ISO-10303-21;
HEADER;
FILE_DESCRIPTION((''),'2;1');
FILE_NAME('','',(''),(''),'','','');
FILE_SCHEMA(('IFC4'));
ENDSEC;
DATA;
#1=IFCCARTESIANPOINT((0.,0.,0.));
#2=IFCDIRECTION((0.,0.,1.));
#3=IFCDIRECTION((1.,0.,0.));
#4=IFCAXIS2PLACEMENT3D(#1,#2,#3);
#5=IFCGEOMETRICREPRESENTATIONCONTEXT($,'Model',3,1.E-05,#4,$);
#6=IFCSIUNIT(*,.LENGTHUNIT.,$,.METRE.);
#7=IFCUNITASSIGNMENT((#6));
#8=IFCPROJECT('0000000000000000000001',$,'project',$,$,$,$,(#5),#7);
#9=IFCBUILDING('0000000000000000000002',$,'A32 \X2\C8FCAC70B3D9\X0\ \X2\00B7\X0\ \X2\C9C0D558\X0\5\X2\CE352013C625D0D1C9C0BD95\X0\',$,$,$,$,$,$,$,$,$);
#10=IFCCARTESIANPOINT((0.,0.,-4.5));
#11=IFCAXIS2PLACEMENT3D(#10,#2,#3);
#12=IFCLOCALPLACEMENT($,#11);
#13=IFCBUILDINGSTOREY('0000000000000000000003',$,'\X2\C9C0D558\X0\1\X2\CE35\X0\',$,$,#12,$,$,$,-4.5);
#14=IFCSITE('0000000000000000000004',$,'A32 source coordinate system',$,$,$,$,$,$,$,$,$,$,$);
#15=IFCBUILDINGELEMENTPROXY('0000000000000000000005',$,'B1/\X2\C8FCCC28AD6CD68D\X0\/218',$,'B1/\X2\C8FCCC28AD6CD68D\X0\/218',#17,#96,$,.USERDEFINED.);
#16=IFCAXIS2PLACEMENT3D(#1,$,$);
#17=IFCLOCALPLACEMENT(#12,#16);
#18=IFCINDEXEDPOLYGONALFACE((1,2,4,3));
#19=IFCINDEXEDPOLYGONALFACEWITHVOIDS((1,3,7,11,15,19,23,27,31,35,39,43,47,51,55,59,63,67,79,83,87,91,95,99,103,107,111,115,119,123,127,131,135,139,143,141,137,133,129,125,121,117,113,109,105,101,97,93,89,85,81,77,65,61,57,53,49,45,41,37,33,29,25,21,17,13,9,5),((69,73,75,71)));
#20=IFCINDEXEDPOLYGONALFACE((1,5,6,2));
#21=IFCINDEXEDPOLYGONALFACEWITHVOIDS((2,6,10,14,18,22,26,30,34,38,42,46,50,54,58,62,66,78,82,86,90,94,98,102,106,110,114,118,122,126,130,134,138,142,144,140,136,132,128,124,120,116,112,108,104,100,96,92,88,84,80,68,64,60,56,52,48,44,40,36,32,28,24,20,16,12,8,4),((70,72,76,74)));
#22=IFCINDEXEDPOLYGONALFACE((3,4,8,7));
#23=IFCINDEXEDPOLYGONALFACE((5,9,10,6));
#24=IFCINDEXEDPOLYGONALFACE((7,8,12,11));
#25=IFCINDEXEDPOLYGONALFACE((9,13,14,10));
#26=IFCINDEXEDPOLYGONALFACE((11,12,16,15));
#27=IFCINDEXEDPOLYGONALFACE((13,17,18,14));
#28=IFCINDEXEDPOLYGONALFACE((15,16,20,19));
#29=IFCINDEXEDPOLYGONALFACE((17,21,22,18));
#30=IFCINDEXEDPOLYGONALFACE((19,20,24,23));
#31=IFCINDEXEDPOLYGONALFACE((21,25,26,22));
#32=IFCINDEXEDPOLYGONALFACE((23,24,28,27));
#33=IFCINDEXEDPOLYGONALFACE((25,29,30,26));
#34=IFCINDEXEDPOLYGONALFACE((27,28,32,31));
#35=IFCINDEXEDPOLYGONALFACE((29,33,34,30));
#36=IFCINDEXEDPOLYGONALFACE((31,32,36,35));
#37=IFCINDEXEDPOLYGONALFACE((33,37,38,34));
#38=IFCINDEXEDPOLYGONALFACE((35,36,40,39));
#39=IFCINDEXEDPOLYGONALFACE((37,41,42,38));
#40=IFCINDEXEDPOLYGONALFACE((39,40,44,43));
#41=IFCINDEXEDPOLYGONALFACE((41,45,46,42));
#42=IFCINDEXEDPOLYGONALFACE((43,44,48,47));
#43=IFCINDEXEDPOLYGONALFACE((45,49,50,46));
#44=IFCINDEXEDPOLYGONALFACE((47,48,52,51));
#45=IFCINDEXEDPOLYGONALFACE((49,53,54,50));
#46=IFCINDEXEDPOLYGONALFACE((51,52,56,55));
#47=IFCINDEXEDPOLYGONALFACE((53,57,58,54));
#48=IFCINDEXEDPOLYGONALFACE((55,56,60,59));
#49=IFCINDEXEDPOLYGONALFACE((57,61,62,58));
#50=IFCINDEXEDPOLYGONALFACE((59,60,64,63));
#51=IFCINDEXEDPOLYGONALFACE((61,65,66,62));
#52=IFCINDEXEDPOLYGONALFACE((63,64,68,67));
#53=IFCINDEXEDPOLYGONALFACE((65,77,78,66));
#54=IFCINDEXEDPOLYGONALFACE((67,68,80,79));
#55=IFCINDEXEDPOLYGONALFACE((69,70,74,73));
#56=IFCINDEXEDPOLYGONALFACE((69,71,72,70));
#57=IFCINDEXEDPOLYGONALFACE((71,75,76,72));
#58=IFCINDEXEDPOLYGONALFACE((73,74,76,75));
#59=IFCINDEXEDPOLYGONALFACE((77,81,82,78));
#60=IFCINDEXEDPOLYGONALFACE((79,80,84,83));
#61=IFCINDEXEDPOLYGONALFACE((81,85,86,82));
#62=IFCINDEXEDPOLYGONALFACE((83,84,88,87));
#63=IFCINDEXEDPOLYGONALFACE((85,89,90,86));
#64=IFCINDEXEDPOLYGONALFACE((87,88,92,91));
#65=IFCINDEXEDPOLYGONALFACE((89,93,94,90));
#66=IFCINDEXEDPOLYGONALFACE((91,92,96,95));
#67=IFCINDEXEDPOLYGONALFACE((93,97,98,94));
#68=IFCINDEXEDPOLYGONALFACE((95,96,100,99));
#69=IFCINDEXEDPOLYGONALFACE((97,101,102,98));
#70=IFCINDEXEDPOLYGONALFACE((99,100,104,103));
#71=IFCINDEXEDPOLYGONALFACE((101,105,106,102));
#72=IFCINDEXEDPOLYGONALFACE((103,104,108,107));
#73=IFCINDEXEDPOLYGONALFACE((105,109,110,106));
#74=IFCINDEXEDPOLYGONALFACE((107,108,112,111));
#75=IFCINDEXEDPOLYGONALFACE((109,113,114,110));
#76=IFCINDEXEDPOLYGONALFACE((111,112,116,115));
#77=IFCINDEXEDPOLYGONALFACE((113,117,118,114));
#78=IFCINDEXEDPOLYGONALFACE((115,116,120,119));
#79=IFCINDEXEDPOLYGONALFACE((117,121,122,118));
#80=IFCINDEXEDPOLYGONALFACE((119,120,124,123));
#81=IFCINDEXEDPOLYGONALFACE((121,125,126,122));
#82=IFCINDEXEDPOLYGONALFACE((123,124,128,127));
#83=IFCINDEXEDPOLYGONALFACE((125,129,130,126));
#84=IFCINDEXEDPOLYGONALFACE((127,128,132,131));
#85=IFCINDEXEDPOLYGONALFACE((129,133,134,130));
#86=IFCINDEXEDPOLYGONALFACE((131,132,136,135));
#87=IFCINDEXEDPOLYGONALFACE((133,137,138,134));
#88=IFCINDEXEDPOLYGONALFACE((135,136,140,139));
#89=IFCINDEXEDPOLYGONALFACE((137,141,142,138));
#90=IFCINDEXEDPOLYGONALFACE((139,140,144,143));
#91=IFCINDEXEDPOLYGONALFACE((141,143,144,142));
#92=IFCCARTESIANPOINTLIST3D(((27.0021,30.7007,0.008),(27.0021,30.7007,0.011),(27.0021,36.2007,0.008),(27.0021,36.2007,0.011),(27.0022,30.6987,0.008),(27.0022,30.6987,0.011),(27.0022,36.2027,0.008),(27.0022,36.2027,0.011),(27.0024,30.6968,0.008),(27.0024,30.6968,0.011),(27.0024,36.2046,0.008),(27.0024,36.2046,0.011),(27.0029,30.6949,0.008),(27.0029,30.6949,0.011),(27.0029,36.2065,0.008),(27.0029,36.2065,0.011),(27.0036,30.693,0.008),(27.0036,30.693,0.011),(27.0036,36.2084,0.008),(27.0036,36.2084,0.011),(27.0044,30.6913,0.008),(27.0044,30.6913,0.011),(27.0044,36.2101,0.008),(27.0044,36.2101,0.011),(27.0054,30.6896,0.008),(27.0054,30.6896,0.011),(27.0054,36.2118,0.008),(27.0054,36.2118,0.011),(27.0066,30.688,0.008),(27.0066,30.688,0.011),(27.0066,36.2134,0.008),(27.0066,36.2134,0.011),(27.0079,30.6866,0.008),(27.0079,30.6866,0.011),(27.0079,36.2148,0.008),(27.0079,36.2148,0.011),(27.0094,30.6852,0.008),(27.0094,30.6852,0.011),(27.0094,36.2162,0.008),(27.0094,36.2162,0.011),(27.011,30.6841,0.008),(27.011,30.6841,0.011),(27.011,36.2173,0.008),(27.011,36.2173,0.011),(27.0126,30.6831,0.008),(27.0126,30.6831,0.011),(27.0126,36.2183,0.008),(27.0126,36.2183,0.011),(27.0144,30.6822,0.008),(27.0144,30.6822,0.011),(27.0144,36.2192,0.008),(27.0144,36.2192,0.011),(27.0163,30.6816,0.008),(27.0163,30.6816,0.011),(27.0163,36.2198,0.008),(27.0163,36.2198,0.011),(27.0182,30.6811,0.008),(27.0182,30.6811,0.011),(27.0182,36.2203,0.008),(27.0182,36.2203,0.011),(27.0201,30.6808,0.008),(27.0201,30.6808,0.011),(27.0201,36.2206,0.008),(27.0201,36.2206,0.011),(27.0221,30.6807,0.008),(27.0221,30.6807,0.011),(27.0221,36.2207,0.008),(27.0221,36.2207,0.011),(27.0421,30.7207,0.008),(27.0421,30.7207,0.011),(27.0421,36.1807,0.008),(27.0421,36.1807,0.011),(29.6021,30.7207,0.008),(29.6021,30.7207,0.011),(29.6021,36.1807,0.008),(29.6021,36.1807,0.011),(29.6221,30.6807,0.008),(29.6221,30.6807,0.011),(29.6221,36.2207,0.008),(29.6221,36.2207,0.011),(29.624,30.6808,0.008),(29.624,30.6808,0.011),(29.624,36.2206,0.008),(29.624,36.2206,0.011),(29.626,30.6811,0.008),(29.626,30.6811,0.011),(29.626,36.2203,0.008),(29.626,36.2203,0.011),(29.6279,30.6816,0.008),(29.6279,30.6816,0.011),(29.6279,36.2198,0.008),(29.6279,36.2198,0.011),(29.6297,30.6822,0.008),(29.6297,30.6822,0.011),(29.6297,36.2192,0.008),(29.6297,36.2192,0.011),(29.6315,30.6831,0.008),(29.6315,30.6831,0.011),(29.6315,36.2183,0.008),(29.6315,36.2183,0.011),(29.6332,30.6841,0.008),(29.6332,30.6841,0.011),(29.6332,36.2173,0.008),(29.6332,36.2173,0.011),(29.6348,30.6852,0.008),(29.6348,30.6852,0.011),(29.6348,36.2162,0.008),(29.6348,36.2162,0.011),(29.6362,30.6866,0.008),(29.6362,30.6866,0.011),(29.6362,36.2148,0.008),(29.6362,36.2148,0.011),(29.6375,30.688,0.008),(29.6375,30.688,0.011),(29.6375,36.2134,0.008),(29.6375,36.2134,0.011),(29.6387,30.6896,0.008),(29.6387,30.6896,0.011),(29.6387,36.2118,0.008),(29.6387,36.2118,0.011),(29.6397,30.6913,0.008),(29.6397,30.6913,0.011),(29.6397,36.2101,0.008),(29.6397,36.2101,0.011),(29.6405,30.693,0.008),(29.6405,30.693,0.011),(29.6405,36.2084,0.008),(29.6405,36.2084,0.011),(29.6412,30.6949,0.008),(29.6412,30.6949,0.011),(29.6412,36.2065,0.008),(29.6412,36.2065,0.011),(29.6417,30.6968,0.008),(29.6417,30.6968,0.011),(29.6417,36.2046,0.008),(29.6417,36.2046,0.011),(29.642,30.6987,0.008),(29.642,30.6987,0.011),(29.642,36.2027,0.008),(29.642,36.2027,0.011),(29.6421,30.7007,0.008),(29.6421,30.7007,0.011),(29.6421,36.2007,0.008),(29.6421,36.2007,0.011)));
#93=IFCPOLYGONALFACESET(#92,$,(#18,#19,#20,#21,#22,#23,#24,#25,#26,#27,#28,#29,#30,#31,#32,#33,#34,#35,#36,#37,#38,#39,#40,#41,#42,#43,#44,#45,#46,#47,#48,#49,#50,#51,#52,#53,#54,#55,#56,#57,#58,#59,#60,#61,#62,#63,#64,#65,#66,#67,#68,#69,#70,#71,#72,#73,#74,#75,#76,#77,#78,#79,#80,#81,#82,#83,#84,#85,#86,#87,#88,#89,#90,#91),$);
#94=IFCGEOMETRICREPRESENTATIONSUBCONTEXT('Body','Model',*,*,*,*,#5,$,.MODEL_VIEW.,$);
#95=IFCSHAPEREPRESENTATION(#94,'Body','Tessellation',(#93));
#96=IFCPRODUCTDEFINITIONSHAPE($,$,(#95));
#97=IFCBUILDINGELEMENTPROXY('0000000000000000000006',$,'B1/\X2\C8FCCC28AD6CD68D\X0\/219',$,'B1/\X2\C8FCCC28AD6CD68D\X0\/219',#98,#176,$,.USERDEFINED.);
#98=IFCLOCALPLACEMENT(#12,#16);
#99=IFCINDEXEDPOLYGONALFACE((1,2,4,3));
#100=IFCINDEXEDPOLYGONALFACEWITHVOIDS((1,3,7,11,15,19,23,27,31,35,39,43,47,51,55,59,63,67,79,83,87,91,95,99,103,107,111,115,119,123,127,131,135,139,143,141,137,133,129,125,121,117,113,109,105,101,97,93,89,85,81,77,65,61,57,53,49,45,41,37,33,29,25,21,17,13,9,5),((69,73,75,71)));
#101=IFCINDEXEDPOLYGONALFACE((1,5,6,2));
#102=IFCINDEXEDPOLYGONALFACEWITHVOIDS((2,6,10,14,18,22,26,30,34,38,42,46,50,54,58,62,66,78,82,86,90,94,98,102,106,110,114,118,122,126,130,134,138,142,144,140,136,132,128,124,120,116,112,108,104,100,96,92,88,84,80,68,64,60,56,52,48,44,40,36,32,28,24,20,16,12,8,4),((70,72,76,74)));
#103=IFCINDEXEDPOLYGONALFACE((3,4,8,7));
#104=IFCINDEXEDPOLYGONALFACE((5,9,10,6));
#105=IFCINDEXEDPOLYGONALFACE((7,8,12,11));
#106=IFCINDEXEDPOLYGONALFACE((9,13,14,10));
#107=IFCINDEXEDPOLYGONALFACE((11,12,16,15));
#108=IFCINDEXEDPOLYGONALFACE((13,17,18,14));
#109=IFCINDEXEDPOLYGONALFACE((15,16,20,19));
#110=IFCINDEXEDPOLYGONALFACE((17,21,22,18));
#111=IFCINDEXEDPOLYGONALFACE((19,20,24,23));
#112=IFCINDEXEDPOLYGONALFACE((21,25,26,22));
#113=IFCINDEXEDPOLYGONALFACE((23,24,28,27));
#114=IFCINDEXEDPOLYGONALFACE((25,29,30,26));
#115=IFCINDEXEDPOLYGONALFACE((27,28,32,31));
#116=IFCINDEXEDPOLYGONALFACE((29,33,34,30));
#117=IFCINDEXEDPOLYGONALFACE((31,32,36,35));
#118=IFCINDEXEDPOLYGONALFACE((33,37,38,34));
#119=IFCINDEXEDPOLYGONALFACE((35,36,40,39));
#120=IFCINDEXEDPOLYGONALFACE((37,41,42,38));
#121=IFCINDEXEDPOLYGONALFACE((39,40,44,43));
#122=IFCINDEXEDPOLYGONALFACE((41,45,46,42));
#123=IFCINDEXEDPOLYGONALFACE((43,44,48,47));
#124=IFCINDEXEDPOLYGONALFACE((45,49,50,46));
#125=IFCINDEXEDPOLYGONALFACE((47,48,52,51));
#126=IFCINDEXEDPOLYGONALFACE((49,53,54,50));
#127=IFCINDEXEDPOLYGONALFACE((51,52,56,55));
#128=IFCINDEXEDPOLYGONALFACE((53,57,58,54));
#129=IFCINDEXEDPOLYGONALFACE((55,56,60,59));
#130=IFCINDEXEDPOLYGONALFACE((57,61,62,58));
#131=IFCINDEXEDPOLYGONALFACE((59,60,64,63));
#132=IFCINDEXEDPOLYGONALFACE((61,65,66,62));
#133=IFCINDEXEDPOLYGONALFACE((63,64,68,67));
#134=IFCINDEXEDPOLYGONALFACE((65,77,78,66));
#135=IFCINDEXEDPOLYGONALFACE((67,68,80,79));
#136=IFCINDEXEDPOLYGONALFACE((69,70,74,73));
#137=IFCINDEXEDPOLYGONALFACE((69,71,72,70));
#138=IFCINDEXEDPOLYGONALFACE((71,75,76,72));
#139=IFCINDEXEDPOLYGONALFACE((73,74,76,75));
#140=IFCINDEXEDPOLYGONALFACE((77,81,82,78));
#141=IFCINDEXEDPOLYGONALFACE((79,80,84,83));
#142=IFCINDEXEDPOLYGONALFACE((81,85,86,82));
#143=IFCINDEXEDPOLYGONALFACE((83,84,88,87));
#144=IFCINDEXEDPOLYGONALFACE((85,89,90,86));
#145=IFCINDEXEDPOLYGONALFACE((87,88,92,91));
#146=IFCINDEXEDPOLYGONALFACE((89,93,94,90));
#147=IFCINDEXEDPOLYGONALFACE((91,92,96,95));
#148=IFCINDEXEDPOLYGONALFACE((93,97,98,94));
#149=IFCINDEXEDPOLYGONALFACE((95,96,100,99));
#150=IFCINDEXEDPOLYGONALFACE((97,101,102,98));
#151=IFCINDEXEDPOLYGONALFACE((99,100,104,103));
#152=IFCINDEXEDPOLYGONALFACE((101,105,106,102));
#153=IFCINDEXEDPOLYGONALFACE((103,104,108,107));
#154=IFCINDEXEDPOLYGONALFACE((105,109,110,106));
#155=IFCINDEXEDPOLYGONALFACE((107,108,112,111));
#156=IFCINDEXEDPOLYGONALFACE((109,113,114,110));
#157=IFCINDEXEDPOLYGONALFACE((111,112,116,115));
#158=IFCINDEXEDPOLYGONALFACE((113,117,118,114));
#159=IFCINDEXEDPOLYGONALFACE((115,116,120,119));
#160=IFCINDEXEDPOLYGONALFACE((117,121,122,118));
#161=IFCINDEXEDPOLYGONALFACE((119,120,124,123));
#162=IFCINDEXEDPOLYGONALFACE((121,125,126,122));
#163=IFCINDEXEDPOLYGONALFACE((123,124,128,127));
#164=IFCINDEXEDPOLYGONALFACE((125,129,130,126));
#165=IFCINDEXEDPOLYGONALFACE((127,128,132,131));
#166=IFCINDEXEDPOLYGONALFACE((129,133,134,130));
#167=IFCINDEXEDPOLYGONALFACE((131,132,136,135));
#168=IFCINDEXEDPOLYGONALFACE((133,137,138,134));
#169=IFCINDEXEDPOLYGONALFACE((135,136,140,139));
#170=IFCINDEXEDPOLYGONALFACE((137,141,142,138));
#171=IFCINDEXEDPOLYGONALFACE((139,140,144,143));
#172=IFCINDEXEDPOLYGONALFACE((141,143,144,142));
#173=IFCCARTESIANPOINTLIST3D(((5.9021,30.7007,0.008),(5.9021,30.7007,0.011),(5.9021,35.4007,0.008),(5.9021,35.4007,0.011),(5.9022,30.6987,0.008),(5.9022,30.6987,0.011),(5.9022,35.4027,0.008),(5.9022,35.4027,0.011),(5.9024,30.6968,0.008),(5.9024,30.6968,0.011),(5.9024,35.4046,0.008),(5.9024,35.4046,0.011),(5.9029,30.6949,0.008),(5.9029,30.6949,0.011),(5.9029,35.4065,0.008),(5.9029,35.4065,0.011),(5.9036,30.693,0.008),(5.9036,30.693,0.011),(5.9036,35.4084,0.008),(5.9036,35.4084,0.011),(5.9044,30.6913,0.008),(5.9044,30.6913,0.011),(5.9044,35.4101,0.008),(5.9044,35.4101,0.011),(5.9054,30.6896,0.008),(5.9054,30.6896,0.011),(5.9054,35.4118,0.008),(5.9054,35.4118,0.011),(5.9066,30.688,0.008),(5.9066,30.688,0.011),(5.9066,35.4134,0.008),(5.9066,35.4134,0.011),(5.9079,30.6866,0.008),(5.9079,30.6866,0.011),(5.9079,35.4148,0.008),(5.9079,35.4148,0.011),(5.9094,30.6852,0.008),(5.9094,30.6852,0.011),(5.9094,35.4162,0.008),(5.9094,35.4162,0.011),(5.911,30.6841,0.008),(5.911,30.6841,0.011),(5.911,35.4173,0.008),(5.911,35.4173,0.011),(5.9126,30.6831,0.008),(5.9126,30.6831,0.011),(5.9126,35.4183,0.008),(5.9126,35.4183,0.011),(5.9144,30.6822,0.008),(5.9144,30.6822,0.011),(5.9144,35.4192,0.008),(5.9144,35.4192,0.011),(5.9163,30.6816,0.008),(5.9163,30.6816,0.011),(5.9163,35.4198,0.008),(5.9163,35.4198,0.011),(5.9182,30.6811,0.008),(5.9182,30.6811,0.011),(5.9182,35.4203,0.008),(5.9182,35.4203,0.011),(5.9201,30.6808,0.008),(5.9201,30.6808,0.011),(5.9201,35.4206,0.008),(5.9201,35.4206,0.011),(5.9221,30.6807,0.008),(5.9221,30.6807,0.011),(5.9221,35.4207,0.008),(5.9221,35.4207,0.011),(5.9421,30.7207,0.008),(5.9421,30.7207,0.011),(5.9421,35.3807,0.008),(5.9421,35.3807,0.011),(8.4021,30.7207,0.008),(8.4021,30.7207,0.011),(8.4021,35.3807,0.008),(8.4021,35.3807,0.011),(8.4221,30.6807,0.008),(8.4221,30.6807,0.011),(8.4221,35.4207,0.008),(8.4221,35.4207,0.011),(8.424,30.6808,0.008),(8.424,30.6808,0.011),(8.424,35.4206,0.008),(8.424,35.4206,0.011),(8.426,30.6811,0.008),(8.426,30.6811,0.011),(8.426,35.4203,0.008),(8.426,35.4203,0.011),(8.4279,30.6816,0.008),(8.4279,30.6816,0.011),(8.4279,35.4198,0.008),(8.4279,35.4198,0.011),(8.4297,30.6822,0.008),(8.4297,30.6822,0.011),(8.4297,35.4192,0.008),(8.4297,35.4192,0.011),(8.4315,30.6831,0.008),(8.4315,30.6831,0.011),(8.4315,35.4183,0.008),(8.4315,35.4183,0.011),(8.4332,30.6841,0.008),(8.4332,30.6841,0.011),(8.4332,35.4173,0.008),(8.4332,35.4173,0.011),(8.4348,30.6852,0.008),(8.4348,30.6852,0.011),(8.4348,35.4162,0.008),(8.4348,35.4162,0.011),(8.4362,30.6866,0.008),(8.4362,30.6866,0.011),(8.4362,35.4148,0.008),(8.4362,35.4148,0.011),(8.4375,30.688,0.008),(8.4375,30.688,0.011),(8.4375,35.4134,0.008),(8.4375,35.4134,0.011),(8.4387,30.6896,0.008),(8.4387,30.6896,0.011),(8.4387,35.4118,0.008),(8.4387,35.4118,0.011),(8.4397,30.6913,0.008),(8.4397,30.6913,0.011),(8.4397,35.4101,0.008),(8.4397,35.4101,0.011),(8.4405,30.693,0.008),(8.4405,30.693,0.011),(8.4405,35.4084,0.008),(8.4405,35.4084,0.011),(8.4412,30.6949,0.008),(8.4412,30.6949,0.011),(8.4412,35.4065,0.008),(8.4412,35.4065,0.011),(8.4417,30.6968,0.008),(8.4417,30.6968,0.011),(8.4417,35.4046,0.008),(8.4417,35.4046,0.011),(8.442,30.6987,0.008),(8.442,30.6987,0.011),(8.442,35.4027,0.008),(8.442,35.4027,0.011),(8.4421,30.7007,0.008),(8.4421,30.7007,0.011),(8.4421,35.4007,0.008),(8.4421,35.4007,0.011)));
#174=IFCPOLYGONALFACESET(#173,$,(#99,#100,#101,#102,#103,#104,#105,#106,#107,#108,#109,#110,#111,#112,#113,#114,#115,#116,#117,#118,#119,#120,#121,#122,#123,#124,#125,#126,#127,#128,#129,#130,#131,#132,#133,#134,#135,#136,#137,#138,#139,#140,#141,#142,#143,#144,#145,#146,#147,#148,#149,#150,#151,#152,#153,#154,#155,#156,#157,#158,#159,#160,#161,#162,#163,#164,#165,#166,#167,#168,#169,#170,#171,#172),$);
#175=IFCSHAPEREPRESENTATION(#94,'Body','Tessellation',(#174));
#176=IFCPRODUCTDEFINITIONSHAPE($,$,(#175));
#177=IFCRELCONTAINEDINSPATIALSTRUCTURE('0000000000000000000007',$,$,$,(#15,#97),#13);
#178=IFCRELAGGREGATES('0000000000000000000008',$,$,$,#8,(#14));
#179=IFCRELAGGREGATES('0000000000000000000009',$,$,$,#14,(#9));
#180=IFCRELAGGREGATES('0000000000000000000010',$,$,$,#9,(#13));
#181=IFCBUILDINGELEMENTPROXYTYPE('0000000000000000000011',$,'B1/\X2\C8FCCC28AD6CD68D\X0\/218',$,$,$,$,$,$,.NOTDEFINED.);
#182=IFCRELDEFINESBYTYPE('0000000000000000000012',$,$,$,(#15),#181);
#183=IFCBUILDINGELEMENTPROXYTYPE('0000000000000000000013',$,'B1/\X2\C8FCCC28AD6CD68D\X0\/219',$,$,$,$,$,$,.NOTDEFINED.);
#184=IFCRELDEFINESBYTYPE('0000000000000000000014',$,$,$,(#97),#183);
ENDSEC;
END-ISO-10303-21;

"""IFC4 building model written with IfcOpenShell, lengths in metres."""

from ifc_helpers import new_model, si_unit, frame, origin, origin_with_axes, place, context, subcontext, project, spatial, polyline, outline, extrude, source, transform, mapped, type_object, type_shapes, element, save


model = new_model("IFC4")

# Units and contexts
model_context = context("Model", 3, precision=1e-05, world=origin_with_axes())
body_context = subcontext(model_context, "Body", "Model", "MODEL_VIEW")
ifc_project = project(units=[si_unit("LENGTHUNIT", "METRE")], contexts=[model_context])

# Site, building, storey
site = spatial("IfcSite", under=ifc_project, Name="A32 source coordinate system")
building = spatial("IfcBuilding", under=site, Name="A32 주거동 · 지하5층–옥탑지붕")
storey_placement = place(None, frame((0.0, 0.0, -4.5), z_axis=(0.0, 0.0, 1.0), x_axis=(1.0, 0.0, 0.0)))
storey = spatial("IfcBuildingStorey", under=building, at=storey_placement, Name="지하1층", Elevation=-4.5)

# Building element proxies
building_element_proxy_type_1 = type_object("IfcBuildingElementProxyType", Name="B1/주차구획/218", PredefinedType="NOTDEFINED")
shared_shape_1 = source(origin(), body_context, "Body", "SweptSolid", [
    extrude(outline(polyline([(27.0021, 36.2007), (27.0022, 36.2027), (27.0024, 36.2046), (27.0029, 36.2065), (27.0036, 36.2084), (27.0044, 36.2101), (27.0054, 36.2118), (27.0066, 36.2134), (27.0079, 36.2148), (27.0094, 36.2162), (27.011, 36.2173), (27.0126, 36.2183), (27.0144, 36.2192), (27.0163, 36.2198), (27.0182, 36.2203), (27.0201, 36.2206), (27.0221, 36.2207), (29.6221, 36.2207), (29.624, 36.2206), (29.626, 36.2203), (29.6279, 36.2198), (29.6297, 36.2192), (29.6315, 36.2183), (29.6332, 36.2173), (29.6348, 36.2162), (29.6362, 36.2148), (29.6375, 36.2134), (29.6387, 36.2118), (29.6397, 36.2101), (29.6405, 36.2084), (29.6412, 36.2065), (29.6417, 36.2046), (29.642, 36.2027), (29.6421, 36.2007), (29.6421, 30.7007), (29.642, 30.6987), (29.6417, 30.6968), (29.6412, 30.6949), (29.6405, 30.693), (29.6397, 30.6913), (29.6387, 30.6896), (29.6375, 30.688), (29.6362, 30.6866), (29.6348, 30.6852), (29.6332, 30.6841), (29.6315, 30.6831), (29.6297, 30.6822), (29.6279, 30.6816), (29.626, 30.6811), (29.624, 30.6808), (29.6221, 30.6807), (27.0221, 30.6807), (27.0201, 30.6808), (27.0182, 30.6811), (27.0163, 30.6816), (27.0144, 30.6822), (27.0126, 30.6831), (27.011, 30.6841), (27.0094, 30.6852), (27.0079, 30.6866), (27.0066, 30.688), (27.0054, 30.6896), (27.0044, 30.6913), (27.0036, 30.693), (27.0029, 30.6949), (27.0024, 30.6968), (27.0022, 30.6987), (27.0021, 30.7007), (27.0021, 36.2007)]), holes=[polyline([(27.0421, 36.1807), (27.0421, 30.7207), (29.6021, 30.7207), (29.6021, 36.1807), (27.0421, 36.1807)])]), frame((0.0, 0.0, 0.008)), (0.0, 0.0, 1.0), 0.003),
])
type_shapes(building_element_proxy_type_1, [shared_shape_1])
proxy_1_placement = place(storey_placement, origin_with_axes())
element("IfcBuildingElementProxy", 1, at=proxy_1_placement, inside=storey, type_object=building_element_proxy_type_1, Name="B1/주차구획/218", ObjectType="B1/주차구획/218", PredefinedType="USERDEFINED", context=body_context, shape_type="MappedRepresentation", body=[
    mapped(shared_shape_1, transform((0.0, 0.0, 0.0), scale=1.0)),
])
building_element_proxy_type_2 = type_object("IfcBuildingElementProxyType", Name="B1/주차구획/219", PredefinedType="NOTDEFINED")
shared_shape_2 = source(origin(), body_context, "Body", "SweptSolid", [
    extrude(outline(polyline([(5.9021, 35.4007), (5.9022, 35.4027), (5.9024, 35.4046), (5.9029, 35.4065), (5.9036, 35.4084), (5.9044, 35.4101), (5.9054, 35.4118), (5.9066, 35.4134), (5.9079, 35.4148), (5.9094, 35.4162), (5.911, 35.4173), (5.9126, 35.4183), (5.9144, 35.4192), (5.9163, 35.4198), (5.9182, 35.4203), (5.9201, 35.4206), (5.9221, 35.4207), (8.4221, 35.4207), (8.424, 35.4206), (8.426, 35.4203), (8.4279, 35.4198), (8.4297, 35.4192), (8.4315, 35.4183), (8.4332, 35.4173), (8.4348, 35.4162), (8.4362, 35.4148), (8.4375, 35.4134), (8.4387, 35.4118), (8.4397, 35.4101), (8.4405, 35.4084), (8.4412, 35.4065), (8.4417, 35.4046), (8.442, 35.4027), (8.4421, 35.4007), (8.4421, 30.7007), (8.442, 30.6987), (8.4417, 30.6968), (8.4412, 30.6949), (8.4405, 30.693), (8.4397, 30.6913), (8.4387, 30.6896), (8.4375, 30.688), (8.4362, 30.6866), (8.4348, 30.6852), (8.4332, 30.6841), (8.4315, 30.6831), (8.4297, 30.6822), (8.4279, 30.6816), (8.426, 30.6811), (8.424, 30.6808), (8.4221, 30.6807), (5.9221, 30.6807), (5.9201, 30.6808), (5.9182, 30.6811), (5.9163, 30.6816), (5.9144, 30.6822), (5.9126, 30.6831), (5.911, 30.6841), (5.9094, 30.6852), (5.9079, 30.6866), (5.9066, 30.688), (5.9054, 30.6896), (5.9044, 30.6913), (5.9036, 30.693), (5.9029, 30.6949), (5.9024, 30.6968), (5.9022, 30.6987), (5.9021, 30.7007), (5.9021, 35.4007)]), holes=[polyline([(5.9421, 35.3807), (5.9421, 30.7207), (8.4021, 30.7207), (8.4021, 35.3807), (5.9421, 35.3807)])]), frame((0.0, 0.0, 0.008)), (0.0, 0.0, 1.0), 0.003),
])
type_shapes(building_element_proxy_type_2, [shared_shape_2])
proxy_2_placement = place(storey_placement, origin_with_axes())
element("IfcBuildingElementProxy", 2, at=proxy_2_placement, inside=storey, type_object=building_element_proxy_type_2, Name="B1/주차구획/219", ObjectType="B1/주차구획/219", PredefinedType="USERDEFINED", context=body_context, shape_type="MappedRepresentation", body=[
    mapped(shared_shape_2, transform((0.0, 0.0, 0.0), scale=1.0)),
])

save(model, "model.ifc")
